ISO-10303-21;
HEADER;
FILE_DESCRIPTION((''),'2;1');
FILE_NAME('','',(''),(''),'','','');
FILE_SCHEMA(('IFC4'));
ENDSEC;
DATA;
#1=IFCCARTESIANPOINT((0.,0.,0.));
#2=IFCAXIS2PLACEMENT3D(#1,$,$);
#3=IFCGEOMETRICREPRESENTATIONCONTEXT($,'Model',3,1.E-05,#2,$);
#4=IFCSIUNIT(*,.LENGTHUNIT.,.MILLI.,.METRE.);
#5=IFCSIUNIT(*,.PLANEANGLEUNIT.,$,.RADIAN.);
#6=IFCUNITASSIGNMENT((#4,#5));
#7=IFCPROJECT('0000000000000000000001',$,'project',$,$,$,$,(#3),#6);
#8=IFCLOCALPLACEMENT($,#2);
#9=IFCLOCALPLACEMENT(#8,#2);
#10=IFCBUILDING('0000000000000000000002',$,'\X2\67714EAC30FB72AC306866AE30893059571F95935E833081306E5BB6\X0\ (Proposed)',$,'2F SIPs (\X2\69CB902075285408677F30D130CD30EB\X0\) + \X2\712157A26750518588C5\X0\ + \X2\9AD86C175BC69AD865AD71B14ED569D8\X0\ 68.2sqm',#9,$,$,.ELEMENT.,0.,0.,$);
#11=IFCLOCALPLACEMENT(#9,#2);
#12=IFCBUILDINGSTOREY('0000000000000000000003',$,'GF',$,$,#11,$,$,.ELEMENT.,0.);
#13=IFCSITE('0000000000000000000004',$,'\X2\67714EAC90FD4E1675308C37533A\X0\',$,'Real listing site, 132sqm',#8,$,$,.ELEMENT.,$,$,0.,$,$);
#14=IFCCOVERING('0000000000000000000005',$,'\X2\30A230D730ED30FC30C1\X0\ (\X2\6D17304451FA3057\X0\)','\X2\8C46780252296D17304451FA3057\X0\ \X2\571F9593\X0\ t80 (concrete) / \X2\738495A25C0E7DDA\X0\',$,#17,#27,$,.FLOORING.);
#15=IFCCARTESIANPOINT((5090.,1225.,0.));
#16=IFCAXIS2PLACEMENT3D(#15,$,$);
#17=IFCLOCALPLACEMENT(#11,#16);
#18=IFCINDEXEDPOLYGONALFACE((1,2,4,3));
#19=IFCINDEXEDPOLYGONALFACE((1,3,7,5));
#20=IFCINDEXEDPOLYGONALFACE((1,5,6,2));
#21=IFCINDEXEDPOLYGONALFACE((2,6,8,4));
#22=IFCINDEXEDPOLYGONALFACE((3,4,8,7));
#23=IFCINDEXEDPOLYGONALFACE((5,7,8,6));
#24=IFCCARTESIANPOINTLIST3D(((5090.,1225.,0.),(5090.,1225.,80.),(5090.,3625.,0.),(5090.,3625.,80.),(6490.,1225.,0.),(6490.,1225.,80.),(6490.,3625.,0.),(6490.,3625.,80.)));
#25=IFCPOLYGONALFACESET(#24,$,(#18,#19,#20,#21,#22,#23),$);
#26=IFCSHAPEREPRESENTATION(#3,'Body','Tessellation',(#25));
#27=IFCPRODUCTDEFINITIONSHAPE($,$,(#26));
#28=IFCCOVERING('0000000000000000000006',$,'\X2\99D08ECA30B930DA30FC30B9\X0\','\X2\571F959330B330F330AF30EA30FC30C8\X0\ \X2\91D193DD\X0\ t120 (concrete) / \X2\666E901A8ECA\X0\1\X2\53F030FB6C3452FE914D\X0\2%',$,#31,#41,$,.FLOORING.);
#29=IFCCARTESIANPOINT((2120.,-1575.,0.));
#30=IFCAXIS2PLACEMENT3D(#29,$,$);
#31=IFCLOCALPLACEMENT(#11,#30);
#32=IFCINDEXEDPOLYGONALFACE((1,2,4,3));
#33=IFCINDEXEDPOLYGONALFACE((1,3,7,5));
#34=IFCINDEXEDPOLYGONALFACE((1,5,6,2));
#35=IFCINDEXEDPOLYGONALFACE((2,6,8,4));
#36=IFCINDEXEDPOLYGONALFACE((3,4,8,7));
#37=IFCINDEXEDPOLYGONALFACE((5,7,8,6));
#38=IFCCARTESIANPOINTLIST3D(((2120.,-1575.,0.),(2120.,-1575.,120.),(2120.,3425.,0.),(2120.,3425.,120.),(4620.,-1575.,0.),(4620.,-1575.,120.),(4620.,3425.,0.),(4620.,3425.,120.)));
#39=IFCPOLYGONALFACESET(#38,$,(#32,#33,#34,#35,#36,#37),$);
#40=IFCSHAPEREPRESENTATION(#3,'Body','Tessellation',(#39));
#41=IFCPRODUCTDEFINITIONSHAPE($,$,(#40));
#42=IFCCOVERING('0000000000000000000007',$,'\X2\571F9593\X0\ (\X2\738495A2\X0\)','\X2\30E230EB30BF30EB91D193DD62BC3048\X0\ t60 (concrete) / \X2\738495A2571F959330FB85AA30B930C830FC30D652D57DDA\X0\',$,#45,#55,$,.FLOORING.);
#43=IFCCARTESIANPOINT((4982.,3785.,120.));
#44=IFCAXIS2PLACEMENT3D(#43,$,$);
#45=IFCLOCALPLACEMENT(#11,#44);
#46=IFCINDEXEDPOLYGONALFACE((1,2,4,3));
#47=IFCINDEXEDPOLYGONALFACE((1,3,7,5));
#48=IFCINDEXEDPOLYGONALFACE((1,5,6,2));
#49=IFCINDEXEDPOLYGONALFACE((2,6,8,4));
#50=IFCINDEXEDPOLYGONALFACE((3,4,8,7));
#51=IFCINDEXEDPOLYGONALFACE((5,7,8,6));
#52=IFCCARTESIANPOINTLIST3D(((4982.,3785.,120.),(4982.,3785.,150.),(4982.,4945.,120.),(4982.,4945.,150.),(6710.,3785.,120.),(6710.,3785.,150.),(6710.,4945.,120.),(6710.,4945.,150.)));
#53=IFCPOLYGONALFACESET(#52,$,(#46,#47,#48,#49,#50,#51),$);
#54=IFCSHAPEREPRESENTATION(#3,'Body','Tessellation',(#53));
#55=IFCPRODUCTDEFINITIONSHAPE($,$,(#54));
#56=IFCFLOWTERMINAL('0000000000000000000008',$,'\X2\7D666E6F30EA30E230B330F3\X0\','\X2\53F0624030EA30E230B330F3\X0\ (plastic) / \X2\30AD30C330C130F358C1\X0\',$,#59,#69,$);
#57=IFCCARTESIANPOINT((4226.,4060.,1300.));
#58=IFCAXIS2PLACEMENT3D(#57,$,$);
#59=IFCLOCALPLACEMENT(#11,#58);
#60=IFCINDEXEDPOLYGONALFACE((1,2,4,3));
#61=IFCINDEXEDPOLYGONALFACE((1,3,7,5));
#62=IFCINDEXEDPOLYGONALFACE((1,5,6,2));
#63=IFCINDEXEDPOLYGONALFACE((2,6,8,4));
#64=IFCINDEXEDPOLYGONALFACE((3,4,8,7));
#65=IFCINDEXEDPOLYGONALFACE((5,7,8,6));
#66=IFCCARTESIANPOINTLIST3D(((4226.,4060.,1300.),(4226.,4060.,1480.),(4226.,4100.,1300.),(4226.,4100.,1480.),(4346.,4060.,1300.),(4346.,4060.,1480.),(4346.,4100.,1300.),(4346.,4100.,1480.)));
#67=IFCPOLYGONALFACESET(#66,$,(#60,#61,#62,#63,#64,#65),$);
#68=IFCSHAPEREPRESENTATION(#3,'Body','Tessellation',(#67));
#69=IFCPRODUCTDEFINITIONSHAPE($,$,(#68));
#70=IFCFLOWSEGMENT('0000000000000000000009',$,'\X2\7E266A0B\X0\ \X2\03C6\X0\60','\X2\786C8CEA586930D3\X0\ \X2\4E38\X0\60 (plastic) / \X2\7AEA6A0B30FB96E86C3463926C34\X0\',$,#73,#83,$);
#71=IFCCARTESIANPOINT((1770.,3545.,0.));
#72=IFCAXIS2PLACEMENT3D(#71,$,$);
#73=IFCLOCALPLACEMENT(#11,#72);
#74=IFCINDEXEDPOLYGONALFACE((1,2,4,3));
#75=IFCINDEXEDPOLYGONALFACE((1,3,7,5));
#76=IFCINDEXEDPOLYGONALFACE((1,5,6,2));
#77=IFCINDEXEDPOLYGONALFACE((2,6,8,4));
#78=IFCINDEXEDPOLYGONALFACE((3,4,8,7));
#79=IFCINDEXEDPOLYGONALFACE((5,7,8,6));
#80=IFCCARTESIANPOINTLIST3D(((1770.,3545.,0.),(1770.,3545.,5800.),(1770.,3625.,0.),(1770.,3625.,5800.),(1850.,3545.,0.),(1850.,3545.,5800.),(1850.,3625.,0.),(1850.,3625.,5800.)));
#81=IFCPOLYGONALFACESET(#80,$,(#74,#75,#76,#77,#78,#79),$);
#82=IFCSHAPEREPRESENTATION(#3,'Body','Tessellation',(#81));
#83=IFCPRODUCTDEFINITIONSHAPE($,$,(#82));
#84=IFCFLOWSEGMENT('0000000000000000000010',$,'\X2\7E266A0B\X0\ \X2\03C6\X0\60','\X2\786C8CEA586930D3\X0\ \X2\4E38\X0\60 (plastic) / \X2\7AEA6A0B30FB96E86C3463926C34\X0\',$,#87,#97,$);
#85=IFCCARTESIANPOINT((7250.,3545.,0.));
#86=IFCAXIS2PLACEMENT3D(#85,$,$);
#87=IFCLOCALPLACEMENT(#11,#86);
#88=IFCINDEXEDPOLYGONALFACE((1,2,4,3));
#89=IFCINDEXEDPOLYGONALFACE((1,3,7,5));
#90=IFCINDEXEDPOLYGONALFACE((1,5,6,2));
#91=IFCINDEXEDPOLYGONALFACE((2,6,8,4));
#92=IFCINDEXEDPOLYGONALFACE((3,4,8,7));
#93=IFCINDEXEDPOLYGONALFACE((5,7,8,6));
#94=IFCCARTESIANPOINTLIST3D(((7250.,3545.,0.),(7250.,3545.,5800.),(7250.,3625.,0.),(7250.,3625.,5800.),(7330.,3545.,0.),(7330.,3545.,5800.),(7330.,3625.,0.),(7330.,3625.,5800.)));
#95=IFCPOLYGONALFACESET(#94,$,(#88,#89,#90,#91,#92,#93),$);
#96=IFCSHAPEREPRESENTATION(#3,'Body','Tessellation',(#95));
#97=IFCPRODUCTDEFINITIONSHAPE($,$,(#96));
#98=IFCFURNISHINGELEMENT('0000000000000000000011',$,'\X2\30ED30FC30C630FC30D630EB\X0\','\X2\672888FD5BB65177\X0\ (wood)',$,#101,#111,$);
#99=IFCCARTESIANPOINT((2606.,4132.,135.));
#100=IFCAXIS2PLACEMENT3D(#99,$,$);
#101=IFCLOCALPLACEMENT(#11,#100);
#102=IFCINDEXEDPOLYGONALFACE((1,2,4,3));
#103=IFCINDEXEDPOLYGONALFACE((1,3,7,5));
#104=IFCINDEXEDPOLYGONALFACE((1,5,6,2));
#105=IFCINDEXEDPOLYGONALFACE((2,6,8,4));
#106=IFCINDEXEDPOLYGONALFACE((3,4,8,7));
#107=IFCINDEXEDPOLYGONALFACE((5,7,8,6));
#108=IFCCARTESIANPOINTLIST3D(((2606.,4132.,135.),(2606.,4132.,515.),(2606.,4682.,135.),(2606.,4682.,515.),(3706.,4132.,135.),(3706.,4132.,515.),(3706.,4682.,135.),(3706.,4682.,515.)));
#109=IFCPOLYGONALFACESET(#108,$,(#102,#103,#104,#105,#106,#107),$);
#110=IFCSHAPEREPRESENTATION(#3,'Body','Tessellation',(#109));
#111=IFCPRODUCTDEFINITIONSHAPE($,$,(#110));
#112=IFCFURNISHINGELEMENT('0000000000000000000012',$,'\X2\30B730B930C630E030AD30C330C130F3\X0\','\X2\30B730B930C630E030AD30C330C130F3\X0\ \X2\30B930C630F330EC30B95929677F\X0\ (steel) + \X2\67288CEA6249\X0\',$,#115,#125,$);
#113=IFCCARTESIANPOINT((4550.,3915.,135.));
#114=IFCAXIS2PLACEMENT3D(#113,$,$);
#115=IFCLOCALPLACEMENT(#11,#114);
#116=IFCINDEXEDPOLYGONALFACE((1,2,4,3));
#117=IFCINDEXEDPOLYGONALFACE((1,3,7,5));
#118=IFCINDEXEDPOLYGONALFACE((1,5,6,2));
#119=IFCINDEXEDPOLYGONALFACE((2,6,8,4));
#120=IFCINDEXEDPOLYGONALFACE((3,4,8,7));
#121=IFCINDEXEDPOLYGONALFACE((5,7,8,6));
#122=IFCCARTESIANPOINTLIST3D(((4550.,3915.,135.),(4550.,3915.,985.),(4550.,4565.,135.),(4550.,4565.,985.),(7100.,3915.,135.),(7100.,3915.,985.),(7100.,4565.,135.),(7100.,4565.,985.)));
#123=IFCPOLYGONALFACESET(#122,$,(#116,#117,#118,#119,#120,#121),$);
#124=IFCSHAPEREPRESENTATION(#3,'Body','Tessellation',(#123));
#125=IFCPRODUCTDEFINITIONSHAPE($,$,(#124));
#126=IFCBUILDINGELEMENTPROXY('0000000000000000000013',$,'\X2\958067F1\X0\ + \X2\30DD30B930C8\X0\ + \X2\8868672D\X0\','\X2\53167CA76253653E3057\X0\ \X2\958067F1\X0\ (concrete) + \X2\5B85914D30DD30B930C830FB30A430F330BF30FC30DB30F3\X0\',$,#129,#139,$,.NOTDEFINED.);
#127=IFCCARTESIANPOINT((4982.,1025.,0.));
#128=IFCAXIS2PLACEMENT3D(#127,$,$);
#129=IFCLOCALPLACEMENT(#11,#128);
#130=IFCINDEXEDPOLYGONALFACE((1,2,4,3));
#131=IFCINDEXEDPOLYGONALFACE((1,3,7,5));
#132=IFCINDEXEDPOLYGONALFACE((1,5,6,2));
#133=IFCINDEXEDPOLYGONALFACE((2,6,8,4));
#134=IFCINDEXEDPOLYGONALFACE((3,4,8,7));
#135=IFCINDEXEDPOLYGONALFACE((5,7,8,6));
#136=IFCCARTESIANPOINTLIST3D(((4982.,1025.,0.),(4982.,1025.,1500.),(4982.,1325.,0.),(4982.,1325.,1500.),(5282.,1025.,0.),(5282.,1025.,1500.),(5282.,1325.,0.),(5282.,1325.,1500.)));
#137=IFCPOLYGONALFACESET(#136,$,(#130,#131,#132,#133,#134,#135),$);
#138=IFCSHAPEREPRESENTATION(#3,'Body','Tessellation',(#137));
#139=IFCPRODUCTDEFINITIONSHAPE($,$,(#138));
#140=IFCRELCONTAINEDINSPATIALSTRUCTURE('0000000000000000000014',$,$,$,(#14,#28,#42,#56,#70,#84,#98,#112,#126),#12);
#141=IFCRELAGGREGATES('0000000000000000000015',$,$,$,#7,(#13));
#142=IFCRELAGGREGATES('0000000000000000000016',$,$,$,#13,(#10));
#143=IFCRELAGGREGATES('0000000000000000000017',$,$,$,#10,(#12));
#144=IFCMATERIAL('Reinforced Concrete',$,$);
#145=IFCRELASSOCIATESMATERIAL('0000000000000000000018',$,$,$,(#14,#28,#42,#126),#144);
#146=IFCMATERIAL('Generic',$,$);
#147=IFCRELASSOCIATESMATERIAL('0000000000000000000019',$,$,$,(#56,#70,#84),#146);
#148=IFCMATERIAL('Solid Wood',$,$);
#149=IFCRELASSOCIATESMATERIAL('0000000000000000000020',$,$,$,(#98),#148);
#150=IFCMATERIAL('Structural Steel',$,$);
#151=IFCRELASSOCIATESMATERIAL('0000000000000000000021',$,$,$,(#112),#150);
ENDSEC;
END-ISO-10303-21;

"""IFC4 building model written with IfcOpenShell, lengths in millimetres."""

from ifc_helpers import new_model, si_unit, frame, frame_2d, origin, place, context, project, spatial, rectangle, extrude, material, element, save


model = new_model("IFC4")

# Units and contexts
model_context = context("Model", 3, precision=1e-05, world=origin())
ifc_project = project(units=[si_unit("LENGTHUNIT", "METRE", prefix="MILLI"), si_unit("PLANEANGLEUNIT", "RADIAN")], contexts=[model_context])

# Site, building, storey
site_placement = place(None, origin())
site = spatial("IfcSite", under=ifc_project, at=site_placement, Name="東京都世田谷区", ObjectType="Real listing site, 132sqm", CompositionType="ELEMENT", RefElevation=0.0)
building_placement = place(site_placement, origin())
building = spatial("IfcBuilding", under=site, at=building_placement, Name="東京・犬と暮らす土間広めの家 (Proposed)", ObjectType="2F SIPs (構造用合板パネル) + 無垢材内装 + 高気密高断熱仕様 68.2sqm", CompositionType="ELEMENT", ElevationOfRefHeight=0.0, ElevationOfTerrain=0.0)
storey_placement = place(building_placement, origin())
storey = spatial("IfcBuildingStorey", under=building, at=storey_placement, Name="GF", CompositionType="ELEMENT", Elevation=0.0)

# Shared definitions
ifc_material_1 = material(Name="Solid Wood")

# Shared definitions
ifc_material_2 = material(Name="Reinforced Concrete")

# Coverings
ifc_material_3 = material(Name="Generic")
covering_1_placement = place(storey_placement, frame((5090.0, 1225.0, 0.0)))
element("IfcCovering", 1, at=covering_1_placement, inside=storey, material=ifc_material_2, Name="アプローチ (洗い出し)", Description="豆砂利洗い出し 土間 t80 (concrete) / 玄関導線", PredefinedType="FLOORING", context=model_context, shape_type="SweptSolid", body=[
    extrude(rectangle(XDim=1400.0, YDim=2400.0, at=frame_2d((700.0, 1200.0))), frame((5090.0, 1225.0, 0.0)), (0.0, 0.0, 1.0), 80.0),
])
covering_2_placement = place(storey_placement, frame((2120.0, -1575.0, 0.0)))
element("IfcCovering", 2, at=covering_2_placement, inside=storey, material=ifc_material_2, Name="駐車スペース", Description="土間コンクリート 金鏝 t120 (concrete) / 普通車1台・水勾配2%", PredefinedType="FLOORING", context=model_context, shape_type="SweptSolid", body=[
    extrude(rectangle(XDim=2500.0, YDim=5000.0, at=frame_2d((1250.0, 2500.0))), frame((2120.0, -1575.0, 0.0)), (0.0, 0.0, 1.0), 120.0),
])
covering_3_placement = place(storey_placement, frame((4982.0, 3785.0, 120.0)))
element("IfcCovering", 3, at=covering_3_placement, inside=storey, material=ifc_material_2, Name="土間 (玄関)", Description="モルタル金鏝押え t60 (concrete) / 玄関土間・薪ストーブ動線", PredefinedType="FLOORING", context=model_context, shape_type="SweptSolid", body=[
    extrude(rectangle(XDim=1728.0, YDim=1160.0, at=frame_2d((864.0, 580.0))), frame((4982.0, 3785.0, 120.0)), (0.0, 0.0, 1.0), 30.0),
])

# Flow terminal
flow_terminal_placement = place(storey_placement, frame((4226.0, 4060.0, 1300.0)))
element("IfcFlowTerminal", 4, at=flow_terminal_placement, inside=storey, material=ifc_material_3, Name="給湯リモコン", Description="台所リモコン (plastic) / キッチン壁", context=model_context, shape_type="SweptSolid", body=[
    extrude(rectangle(XDim=120.0, YDim=40.0, at=frame_2d((60.0, 20.0))), frame((4226.0, 4060.0, 1300.0)), (0.0, 0.0, 1.0), 180.0),
])

# Flow segments
flow_segment_1_placement = place(storey_placement, frame((1770.0, 3545.0, 0.0)))
element("IfcFlowSegment", 5, at=flow_segment_1_placement, inside=storey, material=ifc_material_3, Name="縦樋 φ60", Description="硬質塩ビ 丸60 (plastic) / 竪樋・雨水排水", context=model_context, shape_type="SweptSolid", body=[
    extrude(rectangle(XDim=80.0, YDim=80.0, at=frame_2d((40.0, 40.0))), frame((1770.0, 3545.0, 0.0)), (0.0, 0.0, 1.0), 5800.0),
])
flow_segment_2_placement = place(storey_placement, frame((7250.0, 3545.0, 0.0)))
element("IfcFlowSegment", 6, at=flow_segment_2_placement, inside=storey, material=ifc_material_3, Name="縦樋 φ60", Description="硬質塩ビ 丸60 (plastic) / 竪樋・雨水排水", context=model_context, shape_type="SweptSolid", body=[
    extrude(rectangle(XDim=80.0, YDim=80.0, at=frame_2d((40.0, 40.0))), frame((7250.0, 3545.0, 0.0)), (0.0, 0.0, 1.0), 5800.0),
])

# Furnishing elements
furnishing_1_placement = place(storey_placement, frame((2606.0, 4132.0, 135.0)))
element("IfcFurnishingElement", 7, at=furnishing_1_placement, inside=storey, material=ifc_material_1, Name="ローテーブル", Description="木製家具 (wood)", context=model_context, shape_type="SweptSolid", body=[
    extrude(rectangle(XDim=1100.0, YDim=550.0, at=frame_2d((550.0, 275.0))), frame((2606.0, 4132.0, 135.0)), (0.0, 0.0, 1.0), 380.0),
])
ifc_material_4 = material(Name="Structural Steel")
furnishing_2_placement = place(storey_placement, frame((4550.0, 3915.0, 135.0)))
element("IfcFurnishingElement", 8, at=furnishing_2_placement, inside=storey, material=ifc_material_4, Name="システムキッチン", Description="システムキッチン ステンレス天板 (steel) + 木質扉", context=model_context, shape_type="SweptSolid", body=[
    extrude(rectangle(XDim=2550.0, YDim=650.0, at=frame_2d((1275.0, 325.0))), frame((4550.0, 3915.0, 135.0)), (0.0, 0.0, 1.0), 850.0),
])

# Building element proxy
proxy_placement = place(storey_placement, frame((4982.0, 1025.0, 0.0)))
element("IfcBuildingElementProxy", 9, at=proxy_placement, inside=storey, material=ifc_material_2, Name="門柱 + ポスト + 表札", Description="化粧打放し 門柱 (concrete) + 宅配ポスト・インターホン", PredefinedType="NOTDEFINED", context=model_context, shape_type="SweptSolid", body=[
    extrude(rectangle(XDim=300.0, YDim=300.0, at=frame_2d((150.0, 150.0))), frame((4982.0, 1025.0, 0.0)), (0.0, 0.0, 1.0), 1500.0),
])

save(model, "model.ifc")
